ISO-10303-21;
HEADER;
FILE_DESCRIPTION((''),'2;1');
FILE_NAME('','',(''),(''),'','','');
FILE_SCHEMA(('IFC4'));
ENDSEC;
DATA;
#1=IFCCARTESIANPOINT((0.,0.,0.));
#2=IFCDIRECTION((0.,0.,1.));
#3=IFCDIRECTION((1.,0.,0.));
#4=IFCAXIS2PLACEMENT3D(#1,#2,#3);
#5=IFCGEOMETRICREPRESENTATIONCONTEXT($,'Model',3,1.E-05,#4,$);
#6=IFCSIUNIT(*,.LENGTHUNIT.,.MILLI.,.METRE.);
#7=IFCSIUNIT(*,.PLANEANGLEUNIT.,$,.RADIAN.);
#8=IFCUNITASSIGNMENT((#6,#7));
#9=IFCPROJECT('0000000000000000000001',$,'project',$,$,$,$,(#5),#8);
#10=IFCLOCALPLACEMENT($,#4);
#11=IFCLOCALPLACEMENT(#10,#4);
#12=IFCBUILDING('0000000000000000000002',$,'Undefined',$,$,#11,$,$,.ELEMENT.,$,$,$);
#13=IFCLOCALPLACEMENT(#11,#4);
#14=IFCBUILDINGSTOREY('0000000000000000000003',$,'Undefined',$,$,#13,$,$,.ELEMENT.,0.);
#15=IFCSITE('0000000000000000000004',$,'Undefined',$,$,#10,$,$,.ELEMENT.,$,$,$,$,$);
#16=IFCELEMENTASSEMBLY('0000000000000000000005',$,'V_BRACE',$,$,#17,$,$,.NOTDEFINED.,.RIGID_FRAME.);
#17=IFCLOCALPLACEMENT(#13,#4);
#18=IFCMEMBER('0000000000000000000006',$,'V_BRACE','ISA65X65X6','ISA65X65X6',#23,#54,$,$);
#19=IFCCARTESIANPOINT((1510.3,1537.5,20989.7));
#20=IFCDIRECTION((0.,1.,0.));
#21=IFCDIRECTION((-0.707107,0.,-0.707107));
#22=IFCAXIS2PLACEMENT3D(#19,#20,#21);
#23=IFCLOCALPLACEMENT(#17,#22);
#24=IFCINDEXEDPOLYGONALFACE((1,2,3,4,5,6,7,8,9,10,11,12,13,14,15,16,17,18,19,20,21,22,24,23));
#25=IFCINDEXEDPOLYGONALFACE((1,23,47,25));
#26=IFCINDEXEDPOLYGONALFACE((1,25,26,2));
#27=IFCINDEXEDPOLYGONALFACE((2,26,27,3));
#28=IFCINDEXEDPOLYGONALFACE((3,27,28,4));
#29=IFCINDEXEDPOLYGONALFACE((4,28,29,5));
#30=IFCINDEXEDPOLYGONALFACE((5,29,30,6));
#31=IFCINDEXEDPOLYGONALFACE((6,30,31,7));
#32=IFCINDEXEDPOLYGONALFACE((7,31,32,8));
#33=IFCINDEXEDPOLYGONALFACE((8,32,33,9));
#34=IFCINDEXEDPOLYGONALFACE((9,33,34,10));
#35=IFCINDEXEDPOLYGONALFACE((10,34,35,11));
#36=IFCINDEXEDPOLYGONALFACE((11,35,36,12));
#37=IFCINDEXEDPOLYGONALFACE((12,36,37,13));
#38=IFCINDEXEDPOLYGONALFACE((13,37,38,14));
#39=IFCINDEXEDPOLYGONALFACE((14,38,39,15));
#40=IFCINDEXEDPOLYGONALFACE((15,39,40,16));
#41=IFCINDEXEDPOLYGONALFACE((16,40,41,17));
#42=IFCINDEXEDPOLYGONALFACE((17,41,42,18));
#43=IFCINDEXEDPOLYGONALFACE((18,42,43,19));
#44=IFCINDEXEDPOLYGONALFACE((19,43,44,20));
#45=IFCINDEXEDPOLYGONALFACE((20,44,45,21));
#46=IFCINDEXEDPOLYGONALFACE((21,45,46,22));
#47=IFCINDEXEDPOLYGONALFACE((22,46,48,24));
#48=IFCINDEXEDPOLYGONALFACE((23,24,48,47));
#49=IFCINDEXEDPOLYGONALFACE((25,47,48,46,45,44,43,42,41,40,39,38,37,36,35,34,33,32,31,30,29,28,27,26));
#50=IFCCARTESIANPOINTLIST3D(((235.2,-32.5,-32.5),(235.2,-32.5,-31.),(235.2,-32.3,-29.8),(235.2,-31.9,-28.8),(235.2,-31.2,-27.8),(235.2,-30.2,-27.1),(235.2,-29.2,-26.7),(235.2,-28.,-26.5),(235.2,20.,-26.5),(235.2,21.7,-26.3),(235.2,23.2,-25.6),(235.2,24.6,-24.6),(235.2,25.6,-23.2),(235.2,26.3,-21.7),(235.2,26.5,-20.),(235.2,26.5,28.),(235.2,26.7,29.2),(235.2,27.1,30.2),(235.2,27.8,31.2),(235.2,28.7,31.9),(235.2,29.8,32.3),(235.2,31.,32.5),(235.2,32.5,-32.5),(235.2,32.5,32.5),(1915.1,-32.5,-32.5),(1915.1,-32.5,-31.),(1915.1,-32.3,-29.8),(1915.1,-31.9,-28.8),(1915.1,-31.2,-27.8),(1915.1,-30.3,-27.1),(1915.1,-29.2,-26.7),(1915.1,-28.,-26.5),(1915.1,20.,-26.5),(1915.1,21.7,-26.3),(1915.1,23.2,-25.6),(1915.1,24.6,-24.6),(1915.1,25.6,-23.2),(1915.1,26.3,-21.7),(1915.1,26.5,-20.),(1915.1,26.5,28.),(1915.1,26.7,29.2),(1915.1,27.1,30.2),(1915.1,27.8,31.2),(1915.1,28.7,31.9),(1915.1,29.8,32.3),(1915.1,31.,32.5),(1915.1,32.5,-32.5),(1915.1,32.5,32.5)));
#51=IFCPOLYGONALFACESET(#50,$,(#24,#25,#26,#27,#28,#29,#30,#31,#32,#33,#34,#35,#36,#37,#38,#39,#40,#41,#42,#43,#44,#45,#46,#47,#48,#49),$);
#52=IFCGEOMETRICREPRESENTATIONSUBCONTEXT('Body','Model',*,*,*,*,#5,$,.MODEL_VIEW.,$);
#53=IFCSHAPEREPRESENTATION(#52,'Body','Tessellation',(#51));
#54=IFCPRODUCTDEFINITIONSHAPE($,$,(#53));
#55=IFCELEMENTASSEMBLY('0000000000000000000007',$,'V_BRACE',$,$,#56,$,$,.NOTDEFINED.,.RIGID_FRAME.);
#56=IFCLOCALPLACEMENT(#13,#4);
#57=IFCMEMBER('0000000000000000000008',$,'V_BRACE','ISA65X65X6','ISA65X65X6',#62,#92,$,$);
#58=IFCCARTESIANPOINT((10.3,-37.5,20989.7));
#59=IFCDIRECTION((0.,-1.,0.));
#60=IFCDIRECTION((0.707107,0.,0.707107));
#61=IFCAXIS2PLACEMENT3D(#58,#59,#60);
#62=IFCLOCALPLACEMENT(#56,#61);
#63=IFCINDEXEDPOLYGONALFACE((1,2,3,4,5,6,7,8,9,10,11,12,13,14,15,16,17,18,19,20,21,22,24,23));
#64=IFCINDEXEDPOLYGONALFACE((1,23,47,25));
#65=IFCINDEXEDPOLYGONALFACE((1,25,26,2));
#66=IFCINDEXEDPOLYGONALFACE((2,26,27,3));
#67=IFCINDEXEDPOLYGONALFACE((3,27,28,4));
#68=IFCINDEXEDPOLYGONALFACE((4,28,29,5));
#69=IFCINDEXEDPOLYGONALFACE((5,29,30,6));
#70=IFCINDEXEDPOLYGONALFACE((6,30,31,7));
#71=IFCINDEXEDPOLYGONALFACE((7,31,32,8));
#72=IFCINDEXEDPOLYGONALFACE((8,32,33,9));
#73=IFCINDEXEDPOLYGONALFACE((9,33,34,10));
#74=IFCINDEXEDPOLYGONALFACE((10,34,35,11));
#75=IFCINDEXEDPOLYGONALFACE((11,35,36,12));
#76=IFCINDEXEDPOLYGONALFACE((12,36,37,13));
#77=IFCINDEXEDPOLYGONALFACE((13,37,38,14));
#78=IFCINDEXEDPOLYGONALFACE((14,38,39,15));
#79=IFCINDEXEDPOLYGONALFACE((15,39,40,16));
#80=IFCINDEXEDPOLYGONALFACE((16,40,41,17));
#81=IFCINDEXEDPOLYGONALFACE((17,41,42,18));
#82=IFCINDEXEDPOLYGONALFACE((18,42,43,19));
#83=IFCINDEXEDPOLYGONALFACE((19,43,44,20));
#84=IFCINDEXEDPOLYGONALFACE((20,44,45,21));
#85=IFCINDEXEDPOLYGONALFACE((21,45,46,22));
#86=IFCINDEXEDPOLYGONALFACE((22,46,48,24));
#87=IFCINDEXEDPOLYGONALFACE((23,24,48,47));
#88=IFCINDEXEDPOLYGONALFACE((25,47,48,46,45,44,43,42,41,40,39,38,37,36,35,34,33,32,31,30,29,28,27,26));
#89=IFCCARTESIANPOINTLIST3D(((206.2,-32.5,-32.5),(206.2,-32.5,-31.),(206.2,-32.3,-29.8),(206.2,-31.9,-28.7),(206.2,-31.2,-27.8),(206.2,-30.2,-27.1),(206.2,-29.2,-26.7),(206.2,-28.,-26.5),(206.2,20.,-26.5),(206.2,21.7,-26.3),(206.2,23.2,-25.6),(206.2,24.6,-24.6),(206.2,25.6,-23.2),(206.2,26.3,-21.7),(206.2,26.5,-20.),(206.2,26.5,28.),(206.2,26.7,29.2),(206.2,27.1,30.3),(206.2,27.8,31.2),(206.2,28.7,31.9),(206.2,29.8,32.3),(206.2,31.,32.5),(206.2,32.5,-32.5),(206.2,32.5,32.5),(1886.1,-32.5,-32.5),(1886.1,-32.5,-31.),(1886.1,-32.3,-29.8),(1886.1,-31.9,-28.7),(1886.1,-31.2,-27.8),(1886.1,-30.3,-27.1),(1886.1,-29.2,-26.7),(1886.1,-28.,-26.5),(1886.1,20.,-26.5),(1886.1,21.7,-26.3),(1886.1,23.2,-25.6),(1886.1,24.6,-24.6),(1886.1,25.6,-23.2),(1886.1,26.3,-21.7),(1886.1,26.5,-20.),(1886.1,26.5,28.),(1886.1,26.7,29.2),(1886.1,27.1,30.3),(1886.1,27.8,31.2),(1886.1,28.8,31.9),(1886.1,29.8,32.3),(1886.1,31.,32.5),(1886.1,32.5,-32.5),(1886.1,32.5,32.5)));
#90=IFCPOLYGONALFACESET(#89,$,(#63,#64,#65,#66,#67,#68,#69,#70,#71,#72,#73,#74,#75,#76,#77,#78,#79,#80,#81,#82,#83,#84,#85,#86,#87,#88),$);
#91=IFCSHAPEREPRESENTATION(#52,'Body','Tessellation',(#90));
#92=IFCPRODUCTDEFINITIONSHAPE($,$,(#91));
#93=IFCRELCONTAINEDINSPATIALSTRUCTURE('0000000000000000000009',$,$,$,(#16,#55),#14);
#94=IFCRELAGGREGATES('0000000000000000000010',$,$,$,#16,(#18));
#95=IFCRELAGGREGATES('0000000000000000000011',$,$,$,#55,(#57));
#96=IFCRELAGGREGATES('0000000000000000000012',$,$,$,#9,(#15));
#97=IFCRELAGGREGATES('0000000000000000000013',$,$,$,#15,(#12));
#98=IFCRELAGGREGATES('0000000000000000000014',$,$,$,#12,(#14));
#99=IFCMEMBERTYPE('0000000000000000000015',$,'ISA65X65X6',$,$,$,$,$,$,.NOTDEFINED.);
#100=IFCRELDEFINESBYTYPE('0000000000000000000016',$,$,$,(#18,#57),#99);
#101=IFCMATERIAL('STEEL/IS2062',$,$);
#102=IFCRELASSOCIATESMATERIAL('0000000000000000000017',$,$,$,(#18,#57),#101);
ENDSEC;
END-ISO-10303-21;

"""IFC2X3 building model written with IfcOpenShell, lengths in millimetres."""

from ifc_helpers import new_model, si_unit, frame, origin_with_axes, origin_2d_with_axis, place, context, subcontext, project, spatial, l_section, extrude, clip, halfspace, material, type_object, element, aggregate, save


model = new_model("IFC2X3")

# Units and contexts
model_context = context("Model", 3, precision=1e-05, world=origin_with_axes())
body_context = subcontext(model_context, "Body", "Model", "MODEL_VIEW")
ifc_project = project(units=[si_unit("LENGTHUNIT", "METRE", prefix="MILLI"), si_unit("PLANEANGLEUNIT", "RADIAN")], contexts=[model_context])

# Site, building, storey
site_placement = place(None, origin_with_axes())
site = spatial("IfcSite", under=ifc_project, at=site_placement, Name="Undefined", CompositionType="ELEMENT")
building_placement = place(site_placement, origin_with_axes())
building = spatial("IfcBuilding", under=site, at=building_placement, Name="Undefined", CompositionType="ELEMENT")
storey_placement = place(building_placement, origin_with_axes())
storey = spatial("IfcBuildingStorey", under=building, at=storey_placement, Name="Undefined", CompositionType="ELEMENT", Elevation=0.0)

# Shared definitions
ifc_material = material(Name="STEEL/IS2062")

# Element assemblies, members
member_type = type_object("IfcMemberType", Name="ISA65X65X6", PredefinedType="NOTDEFINED")
assembly_1_placement = place(storey_placement, origin_with_axes())
assembly_1 = element("IfcElementAssembly", 1, at=assembly_1_placement, inside=storey, Name="V_BRACE", AssemblyPlace="NOTDEFINED", PredefinedType="RIGID_FRAME")
member_1_placement = place(assembly_1_placement, frame((1510.3, 1537.5, 20989.7), z_axis=(0.0, 1.0, 0.0), x_axis=(-0.707107, 0.0, -0.707107)))
member_1 = element("IfcMember", 2, at=member_1_placement, type_object=member_type, material=ifc_material, Name="V_BRACE", Description="ISA65X65X6", ObjectType="ISA65X65X6", context=body_context, shape_type="Clipping", body=[
    clip(clip(extrude(l_section(Depth=65.0, Width=65.0, Thickness=6.0, FilletRadius=6.5, EdgeRadius=4.5, at=origin_2d_with_axis()), frame((2121.3, 0.0, 0.0), z_axis=(-1.0, 0.0, 0.0), x_axis=(0.0, -1.0, 0.0)), (0.0, 0.0, 1.0), 2121.3), halfspace(frame((1915.1, 0.0, -42.5), z_axis=(-1.0, 0.0, 0.0), x_axis=(0.0, 1.0, 0.0)), True)), halfspace(frame((235.2, 0.0, -42.5), z_axis=(1.0, 0.0, 0.0), x_axis=(0.0, -1.0, 0.0)), True)),
])
aggregate(assembly_1, [member_1])
assembly_2_placement = place(storey_placement, origin_with_axes())
assembly_2 = element("IfcElementAssembly", 3, at=assembly_2_placement, inside=storey, Name="V_BRACE", AssemblyPlace="NOTDEFINED", PredefinedType="RIGID_FRAME")
member_2_placement = place(assembly_2_placement, frame((10.3, -37.5, 20989.7), z_axis=(0.0, -1.0, 0.0), x_axis=(0.707107, 0.0, 0.707107)))
member_2 = element("IfcMember", 4, at=member_2_placement, type_object=member_type, material=ifc_material, Name="V_BRACE", Description="ISA65X65X6", ObjectType="ISA65X65X6", context=body_context, shape_type="Clipping", body=[
    clip(clip(extrude(l_section(Depth=65.0, Width=65.0, Thickness=6.0, FilletRadius=6.5, EdgeRadius=4.5, at=origin_2d_with_axis()), frame((2121.3, 0.0, 0.0), z_axis=(-1.0, 0.0, 0.0), x_axis=(0.0, -1.0, 0.0)), (0.0, 0.0, 1.0), 2121.3), halfspace(frame((1886.1, 0.0, -32.5), z_axis=(-1.0, 0.0, 0.0), x_axis=(0.0, -1.0, 0.0)), True)), halfspace(frame((206.2, 0.0, -32.5), z_axis=(1.0, 0.0, 0.0), x_axis=(0.0, 1.0, 0.0)), True)),
])
aggregate(assembly_2, [member_2])

save(model, "model.ifc")
